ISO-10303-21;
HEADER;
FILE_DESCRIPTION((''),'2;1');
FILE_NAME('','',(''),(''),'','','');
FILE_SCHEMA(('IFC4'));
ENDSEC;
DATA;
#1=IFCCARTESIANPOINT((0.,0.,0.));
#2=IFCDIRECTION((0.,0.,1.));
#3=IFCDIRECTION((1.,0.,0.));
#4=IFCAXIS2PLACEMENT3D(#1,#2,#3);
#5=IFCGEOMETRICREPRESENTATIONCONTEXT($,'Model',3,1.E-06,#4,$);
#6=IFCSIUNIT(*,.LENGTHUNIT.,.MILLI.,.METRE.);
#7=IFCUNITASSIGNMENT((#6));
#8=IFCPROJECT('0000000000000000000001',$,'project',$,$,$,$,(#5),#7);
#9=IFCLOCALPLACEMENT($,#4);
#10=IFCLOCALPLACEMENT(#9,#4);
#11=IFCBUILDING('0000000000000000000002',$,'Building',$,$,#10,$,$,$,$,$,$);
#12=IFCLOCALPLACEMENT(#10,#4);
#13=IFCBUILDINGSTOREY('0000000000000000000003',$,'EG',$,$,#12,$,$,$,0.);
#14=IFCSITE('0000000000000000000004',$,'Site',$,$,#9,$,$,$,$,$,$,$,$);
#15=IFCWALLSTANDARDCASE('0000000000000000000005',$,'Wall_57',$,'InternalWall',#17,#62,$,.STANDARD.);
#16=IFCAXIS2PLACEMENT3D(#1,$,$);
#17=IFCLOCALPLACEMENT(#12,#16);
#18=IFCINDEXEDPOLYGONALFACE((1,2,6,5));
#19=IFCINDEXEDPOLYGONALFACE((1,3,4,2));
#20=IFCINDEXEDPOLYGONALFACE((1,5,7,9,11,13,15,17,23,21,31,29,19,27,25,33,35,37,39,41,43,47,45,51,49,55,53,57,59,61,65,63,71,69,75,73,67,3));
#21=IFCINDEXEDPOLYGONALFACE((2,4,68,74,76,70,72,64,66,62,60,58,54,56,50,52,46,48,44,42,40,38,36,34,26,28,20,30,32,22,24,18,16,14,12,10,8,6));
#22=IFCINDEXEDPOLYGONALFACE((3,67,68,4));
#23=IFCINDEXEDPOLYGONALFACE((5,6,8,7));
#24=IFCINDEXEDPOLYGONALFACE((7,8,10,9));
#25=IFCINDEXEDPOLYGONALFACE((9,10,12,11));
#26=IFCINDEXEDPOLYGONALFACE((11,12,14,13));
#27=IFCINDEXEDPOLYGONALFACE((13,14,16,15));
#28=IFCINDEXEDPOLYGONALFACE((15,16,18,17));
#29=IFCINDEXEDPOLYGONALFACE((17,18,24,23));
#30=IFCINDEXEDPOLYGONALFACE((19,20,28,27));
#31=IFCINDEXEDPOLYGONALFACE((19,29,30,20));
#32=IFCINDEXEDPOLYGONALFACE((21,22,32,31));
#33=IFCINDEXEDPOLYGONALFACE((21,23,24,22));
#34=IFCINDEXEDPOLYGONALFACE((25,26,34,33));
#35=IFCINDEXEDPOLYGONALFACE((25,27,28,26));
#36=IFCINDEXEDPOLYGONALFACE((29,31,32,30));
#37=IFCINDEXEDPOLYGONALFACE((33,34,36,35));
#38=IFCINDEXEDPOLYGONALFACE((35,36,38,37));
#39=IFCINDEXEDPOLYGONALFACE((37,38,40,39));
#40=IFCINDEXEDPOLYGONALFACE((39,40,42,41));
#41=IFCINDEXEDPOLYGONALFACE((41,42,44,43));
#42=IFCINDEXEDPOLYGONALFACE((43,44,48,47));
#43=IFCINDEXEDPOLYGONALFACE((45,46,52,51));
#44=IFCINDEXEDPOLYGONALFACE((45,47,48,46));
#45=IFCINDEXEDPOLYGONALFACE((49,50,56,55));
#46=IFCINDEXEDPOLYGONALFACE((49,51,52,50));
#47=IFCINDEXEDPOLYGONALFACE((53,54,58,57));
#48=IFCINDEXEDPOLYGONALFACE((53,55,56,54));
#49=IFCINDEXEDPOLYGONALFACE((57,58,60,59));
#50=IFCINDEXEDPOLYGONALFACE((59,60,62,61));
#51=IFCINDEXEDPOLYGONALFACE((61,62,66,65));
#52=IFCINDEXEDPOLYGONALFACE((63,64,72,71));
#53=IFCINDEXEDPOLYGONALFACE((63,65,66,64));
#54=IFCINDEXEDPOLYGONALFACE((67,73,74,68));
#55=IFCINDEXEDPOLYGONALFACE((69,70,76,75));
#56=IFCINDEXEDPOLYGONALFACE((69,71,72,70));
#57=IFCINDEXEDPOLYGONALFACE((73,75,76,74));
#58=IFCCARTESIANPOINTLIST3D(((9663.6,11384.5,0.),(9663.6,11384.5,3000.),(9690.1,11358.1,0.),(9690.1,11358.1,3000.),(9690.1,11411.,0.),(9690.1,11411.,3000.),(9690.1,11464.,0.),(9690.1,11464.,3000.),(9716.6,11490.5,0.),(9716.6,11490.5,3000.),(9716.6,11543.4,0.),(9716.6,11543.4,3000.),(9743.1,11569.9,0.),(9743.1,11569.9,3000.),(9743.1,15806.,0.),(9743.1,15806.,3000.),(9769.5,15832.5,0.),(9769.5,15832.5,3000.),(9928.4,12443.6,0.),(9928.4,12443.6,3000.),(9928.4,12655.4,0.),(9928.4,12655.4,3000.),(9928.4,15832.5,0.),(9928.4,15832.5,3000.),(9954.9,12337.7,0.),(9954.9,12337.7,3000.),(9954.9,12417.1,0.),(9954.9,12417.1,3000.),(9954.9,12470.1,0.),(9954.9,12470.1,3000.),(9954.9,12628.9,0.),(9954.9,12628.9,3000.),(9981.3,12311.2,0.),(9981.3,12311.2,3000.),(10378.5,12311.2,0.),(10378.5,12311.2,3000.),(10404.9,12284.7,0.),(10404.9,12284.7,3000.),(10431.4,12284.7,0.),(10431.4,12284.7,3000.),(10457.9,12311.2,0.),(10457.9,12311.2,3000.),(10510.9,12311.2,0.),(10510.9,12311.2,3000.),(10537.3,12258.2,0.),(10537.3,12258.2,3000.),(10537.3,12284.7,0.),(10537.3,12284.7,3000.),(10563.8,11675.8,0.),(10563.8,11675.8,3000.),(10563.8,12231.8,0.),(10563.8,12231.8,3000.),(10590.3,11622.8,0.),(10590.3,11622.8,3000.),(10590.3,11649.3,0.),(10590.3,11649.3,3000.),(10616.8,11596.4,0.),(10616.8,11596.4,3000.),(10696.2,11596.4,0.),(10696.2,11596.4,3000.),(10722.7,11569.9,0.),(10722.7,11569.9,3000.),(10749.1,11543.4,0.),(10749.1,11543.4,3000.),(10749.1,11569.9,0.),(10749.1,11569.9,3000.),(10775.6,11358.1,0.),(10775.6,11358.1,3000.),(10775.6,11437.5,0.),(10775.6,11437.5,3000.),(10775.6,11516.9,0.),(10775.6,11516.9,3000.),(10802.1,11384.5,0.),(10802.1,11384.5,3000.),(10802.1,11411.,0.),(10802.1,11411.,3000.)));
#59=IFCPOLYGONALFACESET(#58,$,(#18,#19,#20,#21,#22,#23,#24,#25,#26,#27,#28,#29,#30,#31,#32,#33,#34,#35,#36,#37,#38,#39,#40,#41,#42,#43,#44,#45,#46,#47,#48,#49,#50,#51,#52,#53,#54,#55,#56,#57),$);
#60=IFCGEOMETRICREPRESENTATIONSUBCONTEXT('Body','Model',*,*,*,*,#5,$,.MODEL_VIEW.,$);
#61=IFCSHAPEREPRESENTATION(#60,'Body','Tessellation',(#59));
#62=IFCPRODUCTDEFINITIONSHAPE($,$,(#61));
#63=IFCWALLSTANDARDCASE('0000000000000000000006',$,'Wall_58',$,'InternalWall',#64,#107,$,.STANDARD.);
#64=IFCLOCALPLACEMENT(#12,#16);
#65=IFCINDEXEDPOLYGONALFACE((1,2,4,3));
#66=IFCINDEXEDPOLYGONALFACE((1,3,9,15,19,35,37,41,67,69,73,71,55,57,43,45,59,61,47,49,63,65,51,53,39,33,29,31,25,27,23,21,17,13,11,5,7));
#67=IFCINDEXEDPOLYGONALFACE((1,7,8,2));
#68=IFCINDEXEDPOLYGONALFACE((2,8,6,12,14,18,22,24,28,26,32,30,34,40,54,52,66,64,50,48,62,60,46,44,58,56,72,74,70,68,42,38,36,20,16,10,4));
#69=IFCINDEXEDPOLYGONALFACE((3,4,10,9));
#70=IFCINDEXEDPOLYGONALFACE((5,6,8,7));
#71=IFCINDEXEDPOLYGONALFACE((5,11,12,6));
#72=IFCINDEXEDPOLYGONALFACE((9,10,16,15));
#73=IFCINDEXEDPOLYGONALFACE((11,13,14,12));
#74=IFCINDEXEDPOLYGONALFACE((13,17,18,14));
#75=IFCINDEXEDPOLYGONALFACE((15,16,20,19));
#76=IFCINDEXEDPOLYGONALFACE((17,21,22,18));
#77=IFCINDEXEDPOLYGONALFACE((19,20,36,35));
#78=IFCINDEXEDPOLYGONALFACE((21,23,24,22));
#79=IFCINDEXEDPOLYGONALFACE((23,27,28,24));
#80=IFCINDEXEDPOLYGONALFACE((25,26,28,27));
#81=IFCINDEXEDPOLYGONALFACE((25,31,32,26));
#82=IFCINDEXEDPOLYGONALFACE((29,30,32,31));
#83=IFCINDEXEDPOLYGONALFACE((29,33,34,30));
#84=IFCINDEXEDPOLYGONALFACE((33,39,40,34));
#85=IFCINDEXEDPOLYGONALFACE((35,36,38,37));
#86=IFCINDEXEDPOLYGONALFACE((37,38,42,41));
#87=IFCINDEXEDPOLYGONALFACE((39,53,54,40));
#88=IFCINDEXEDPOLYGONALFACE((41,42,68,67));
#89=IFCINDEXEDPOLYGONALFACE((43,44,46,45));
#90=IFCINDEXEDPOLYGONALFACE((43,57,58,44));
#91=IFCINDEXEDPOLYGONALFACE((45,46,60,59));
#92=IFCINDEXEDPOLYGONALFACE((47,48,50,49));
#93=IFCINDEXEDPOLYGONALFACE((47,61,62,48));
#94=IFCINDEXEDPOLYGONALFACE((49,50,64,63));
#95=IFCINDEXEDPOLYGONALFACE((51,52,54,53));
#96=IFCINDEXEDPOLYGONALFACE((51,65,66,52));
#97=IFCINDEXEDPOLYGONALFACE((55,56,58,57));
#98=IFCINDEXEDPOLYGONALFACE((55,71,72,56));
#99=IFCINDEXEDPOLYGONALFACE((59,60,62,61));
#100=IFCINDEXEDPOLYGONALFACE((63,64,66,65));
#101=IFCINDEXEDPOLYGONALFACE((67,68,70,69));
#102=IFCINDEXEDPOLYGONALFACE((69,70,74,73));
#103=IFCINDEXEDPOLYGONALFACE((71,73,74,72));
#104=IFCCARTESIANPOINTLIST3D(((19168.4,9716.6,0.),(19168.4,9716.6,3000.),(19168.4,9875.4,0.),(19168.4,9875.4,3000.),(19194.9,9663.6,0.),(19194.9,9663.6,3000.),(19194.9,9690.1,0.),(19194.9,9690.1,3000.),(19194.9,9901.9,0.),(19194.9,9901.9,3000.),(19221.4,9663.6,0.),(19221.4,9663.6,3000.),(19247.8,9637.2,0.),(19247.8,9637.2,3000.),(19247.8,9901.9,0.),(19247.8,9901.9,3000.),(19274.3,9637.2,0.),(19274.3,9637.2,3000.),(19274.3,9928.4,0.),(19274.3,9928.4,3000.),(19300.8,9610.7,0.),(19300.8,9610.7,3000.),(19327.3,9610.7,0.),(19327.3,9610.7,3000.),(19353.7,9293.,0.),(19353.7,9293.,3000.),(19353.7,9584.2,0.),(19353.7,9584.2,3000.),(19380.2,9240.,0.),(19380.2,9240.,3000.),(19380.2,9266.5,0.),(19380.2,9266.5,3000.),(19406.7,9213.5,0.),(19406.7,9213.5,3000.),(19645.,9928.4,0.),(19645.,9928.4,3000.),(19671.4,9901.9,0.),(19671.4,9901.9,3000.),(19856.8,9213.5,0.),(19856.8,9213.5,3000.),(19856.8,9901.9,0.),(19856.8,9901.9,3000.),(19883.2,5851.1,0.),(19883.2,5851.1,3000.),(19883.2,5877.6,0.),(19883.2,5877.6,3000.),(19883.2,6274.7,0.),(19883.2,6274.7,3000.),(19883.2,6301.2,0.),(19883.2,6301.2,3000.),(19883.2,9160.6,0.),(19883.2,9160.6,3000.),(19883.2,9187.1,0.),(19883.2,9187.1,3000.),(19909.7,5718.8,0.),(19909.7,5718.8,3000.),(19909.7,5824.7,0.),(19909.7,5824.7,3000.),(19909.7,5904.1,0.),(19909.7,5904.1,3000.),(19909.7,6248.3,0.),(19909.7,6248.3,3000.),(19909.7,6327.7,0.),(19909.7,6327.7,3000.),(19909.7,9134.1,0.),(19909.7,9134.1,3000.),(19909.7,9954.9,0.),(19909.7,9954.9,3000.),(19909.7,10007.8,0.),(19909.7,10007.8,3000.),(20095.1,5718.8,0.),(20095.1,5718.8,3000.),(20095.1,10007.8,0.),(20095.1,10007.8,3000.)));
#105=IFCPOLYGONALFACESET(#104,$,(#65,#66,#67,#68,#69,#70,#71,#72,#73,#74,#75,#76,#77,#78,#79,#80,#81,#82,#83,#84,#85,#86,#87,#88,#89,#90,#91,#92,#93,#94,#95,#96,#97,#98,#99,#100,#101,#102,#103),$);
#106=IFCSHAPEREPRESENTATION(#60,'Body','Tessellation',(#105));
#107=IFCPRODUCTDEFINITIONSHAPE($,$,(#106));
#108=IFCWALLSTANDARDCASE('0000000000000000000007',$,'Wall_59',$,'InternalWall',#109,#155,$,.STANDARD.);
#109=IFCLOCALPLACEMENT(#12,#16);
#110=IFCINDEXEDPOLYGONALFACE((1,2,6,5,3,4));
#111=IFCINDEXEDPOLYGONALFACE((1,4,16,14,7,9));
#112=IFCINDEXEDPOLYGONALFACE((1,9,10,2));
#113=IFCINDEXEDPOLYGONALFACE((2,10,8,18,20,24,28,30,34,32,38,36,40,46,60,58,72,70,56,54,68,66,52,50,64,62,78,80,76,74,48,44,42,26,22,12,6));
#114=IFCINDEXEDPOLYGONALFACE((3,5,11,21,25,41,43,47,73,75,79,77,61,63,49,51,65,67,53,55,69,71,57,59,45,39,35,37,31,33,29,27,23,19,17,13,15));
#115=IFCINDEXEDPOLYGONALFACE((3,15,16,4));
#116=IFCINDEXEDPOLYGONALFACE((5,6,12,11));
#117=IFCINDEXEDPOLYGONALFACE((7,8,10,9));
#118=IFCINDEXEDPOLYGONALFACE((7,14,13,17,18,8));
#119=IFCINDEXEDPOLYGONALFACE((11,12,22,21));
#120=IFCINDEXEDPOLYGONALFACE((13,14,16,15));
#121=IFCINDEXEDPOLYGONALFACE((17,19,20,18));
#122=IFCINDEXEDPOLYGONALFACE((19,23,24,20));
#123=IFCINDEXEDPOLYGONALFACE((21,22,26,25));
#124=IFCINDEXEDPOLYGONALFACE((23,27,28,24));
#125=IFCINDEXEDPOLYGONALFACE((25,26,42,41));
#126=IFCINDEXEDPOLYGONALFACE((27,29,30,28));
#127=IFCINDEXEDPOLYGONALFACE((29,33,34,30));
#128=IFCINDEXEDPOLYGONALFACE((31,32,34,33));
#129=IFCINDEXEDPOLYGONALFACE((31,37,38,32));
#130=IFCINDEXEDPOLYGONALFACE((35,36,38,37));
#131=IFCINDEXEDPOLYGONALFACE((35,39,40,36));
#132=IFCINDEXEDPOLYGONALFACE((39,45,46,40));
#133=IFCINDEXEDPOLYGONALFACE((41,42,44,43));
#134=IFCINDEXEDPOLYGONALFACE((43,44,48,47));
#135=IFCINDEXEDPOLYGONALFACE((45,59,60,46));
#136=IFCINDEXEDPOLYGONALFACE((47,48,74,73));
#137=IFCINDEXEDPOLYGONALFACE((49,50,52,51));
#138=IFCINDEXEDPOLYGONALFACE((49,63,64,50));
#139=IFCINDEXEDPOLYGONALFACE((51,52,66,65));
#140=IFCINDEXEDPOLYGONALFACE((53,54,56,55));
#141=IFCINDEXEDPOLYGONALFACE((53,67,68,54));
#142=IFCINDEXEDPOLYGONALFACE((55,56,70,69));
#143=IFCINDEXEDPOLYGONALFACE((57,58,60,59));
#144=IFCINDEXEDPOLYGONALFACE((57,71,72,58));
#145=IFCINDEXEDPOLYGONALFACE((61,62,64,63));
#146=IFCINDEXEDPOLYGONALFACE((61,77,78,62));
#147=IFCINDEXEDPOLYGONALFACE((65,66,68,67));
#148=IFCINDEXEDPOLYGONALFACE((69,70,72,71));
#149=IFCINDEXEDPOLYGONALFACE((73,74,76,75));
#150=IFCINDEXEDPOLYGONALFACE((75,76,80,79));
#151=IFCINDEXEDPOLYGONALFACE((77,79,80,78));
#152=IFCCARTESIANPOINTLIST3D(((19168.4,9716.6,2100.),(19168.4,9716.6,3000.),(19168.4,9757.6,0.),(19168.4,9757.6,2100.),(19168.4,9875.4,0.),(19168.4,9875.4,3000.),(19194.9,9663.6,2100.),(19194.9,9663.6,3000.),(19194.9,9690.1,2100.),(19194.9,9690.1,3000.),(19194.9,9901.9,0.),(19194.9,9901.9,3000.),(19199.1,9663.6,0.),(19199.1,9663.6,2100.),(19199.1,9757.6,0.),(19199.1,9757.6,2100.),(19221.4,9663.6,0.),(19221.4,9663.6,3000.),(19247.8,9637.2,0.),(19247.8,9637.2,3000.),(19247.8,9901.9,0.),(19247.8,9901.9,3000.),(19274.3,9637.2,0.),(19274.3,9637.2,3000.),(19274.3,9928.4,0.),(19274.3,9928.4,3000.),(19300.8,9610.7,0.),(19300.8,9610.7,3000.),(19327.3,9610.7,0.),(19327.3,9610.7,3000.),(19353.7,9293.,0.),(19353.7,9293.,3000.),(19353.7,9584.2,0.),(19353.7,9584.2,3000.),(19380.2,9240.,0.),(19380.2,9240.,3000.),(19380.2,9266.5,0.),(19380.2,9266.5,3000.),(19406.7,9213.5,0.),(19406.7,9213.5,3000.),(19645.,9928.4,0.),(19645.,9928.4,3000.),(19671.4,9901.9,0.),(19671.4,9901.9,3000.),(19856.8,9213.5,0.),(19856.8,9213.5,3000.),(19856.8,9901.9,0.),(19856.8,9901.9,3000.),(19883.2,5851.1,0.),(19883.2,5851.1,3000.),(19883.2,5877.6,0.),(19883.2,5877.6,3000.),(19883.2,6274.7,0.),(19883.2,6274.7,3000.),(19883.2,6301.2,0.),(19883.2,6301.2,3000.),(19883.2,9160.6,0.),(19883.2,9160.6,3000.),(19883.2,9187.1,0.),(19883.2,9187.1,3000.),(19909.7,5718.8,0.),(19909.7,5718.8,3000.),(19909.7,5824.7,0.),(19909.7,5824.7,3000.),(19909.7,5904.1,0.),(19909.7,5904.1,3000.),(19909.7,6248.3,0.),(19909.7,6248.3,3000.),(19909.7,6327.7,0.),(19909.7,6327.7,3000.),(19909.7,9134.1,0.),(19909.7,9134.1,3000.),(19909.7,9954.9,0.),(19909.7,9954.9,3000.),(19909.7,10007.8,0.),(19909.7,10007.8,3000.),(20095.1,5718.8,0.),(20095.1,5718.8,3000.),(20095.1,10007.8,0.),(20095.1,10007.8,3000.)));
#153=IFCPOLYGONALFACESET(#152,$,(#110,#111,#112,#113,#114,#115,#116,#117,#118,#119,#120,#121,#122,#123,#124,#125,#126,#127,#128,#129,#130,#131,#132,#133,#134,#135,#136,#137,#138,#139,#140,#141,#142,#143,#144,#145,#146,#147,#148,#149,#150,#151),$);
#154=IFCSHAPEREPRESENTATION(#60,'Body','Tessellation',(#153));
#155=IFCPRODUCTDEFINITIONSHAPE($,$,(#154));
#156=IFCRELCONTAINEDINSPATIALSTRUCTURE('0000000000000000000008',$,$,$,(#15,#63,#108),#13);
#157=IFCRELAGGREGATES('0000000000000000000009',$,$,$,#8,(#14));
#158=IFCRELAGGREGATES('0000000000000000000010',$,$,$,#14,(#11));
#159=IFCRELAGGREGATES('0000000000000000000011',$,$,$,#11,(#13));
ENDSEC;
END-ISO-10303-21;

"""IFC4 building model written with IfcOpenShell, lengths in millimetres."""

from ifc_helpers import new_model, si_unit, frame, origin_with_axes, place, context, subcontext, project, spatial, polyline, rectangle, outline, extrude, element, save


model = new_model("IFC4")

# Units and contexts
model_context = context("Model", 3, precision=1e-06, world=origin_with_axes())
body_context = subcontext(model_context, "Body", "Model", "MODEL_VIEW")
ifc_project = project(units=[si_unit("LENGTHUNIT", "METRE", prefix="MILLI")], contexts=[model_context])

# Site, building, storey
site_placement = place(None, origin_with_axes())
site = spatial("IfcSite", under=ifc_project, at=site_placement, Name="Site")
building_placement = place(site_placement, origin_with_axes())
building = spatial("IfcBuilding", under=site, at=building_placement, Name="Building")
storey_placement = place(building_placement, origin_with_axes())
storey = spatial("IfcBuildingStorey", under=building, at=storey_placement, Name="EG", Elevation=0.0)

# Walls
wall_1_placement = place(storey_placement, origin_with_axes())
element("IfcWallStandardCase", 1, at=wall_1_placement, inside=storey, Name="Wall_57", ObjectType="InternalWall", PredefinedType="STANDARD", context=body_context, shape_type="SweptSolid", body=[
    extrude(outline(polyline([(9690.1, 11358.1, 0.0), (9663.6, 11384.5, 0.0), (9690.1, 11411.0, 0.0), (9690.1, 11464.0, 0.0), (9716.6, 11490.5, 0.0), (9716.6, 11543.4, 0.0), (9743.1, 11569.9, 0.0), (9743.1, 15806.0, 0.0), (9769.5, 15832.5, 0.0), (9928.4, 15832.5, 0.0), (9928.4, 12655.4, 0.0), (9954.9, 12628.9, 0.0), (9954.9, 12470.1, 0.0), (9928.4, 12443.6, 0.0), (9954.9, 12417.1, 0.0), (9954.9, 12337.7, 0.0), (9981.3, 12311.2, 0.0), (10378.5, 12311.2, 0.0), (10404.9, 12284.7, 0.0), (10431.4, 12284.7, 0.0), (10457.9, 12311.2, 0.0), (10510.9, 12311.2, 0.0), (10537.3, 12284.7, 0.0), (10537.3, 12258.2, 0.0), (10563.8, 12231.8, 0.0), (10563.8, 11675.8, 0.0), (10590.3, 11649.3, 0.0), (10590.3, 11622.8, 0.0), (10616.8, 11596.4, 0.0), (10696.2, 11596.4, 0.0), (10722.7, 11569.9, 0.0), (10749.1, 11569.9, 0.0), (10749.1, 11543.4, 0.0), (10775.6, 11516.9, 0.0), (10775.6, 11437.5, 0.0), (10802.1, 11411.0, 0.0), (10802.1, 11384.5, 0.0), (10775.6, 11358.1, 0.0), (9690.1, 11358.1, 0.0)])), origin_with_axes(), (0.0, 0.0, 1.0), 3000.0),
])
wall_2_placement = place(storey_placement, origin_with_axes())
element("IfcWallStandardCase", 2, at=wall_2_placement, inside=storey, Name="Wall_58", ObjectType="InternalWall", PredefinedType="STANDARD", context=body_context, shape_type="SweptSolid", body=[
    extrude(outline(polyline([(19909.7, 5718.8, 0.0), (19909.7, 5824.7, 0.0), (19883.2, 5851.1, 0.0), (19883.2, 5877.6, 0.0), (19909.7, 5904.1, 0.0), (19909.7, 6248.3, 0.0), (19883.2, 6274.7, 0.0), (19883.2, 6301.2, 0.0), (19909.7, 6327.7, 0.0), (19909.7, 9134.1, 0.0), (19883.2, 9160.6, 0.0), (19883.2, 9187.1, 0.0), (19856.8, 9213.5, 0.0), (19406.7, 9213.5, 0.0), (19380.2, 9240.0, 0.0), (19380.2, 9266.5, 0.0), (19353.7, 9293.0, 0.0), (19353.7, 9584.2, 0.0), (19327.3, 9610.7, 0.0), (19300.8, 9610.7, 0.0), (19274.3, 9637.2, 0.0), (19247.8, 9637.2, 0.0), (19221.4, 9663.6, 0.0), (19194.9, 9663.6, 0.0), (19194.9, 9690.1, 0.0), (19168.4, 9716.6, 0.0), (19168.4, 9875.4, 0.0), (19194.9, 9901.9, 0.0), (19247.8, 9901.9, 0.0), (19274.3, 9928.4, 0.0), (19645.0, 9928.4, 0.0), (19671.4, 9901.9, 0.0), (19856.8, 9901.9, 0.0), (19909.7, 9954.9, 0.0), (19909.7, 10007.8, 0.0), (20095.1, 10007.8, 0.0), (20095.1, 5718.8, 0.0), (19909.7, 5718.8, 0.0)])), origin_with_axes(), (0.0, 0.0, 1.0), 3000.0),
])

# Wall, opening
wall_3_placement = place(storey_placement, origin_with_axes())
wall_3 = element("IfcWallStandardCase", 3, at=wall_3_placement, inside=storey, Name="Wall_59", ObjectType="InternalWall", PredefinedType="STANDARD", context=body_context, shape_type="SweptSolid", body=[
    extrude(outline(polyline([(19909.7, 5718.8, 0.0), (19909.7, 5824.7, 0.0), (19883.2, 5851.1, 0.0), (19883.2, 5877.6, 0.0), (19909.7, 5904.1, 0.0), (19909.7, 6248.3, 0.0), (19883.2, 6274.7, 0.0), (19883.2, 6301.2, 0.0), (19909.7, 6327.7, 0.0), (19909.7, 9134.1, 0.0), (19883.2, 9160.6, 0.0), (19883.2, 9187.1, 0.0), (19856.8, 9213.5, 0.0), (19406.7, 9213.5, 0.0), (19380.2, 9240.0, 0.0), (19380.2, 9266.5, 0.0), (19353.7, 9293.0, 0.0), (19353.7, 9584.2, 0.0), (19327.3, 9610.7, 0.0), (19300.8, 9610.7, 0.0), (19274.3, 9637.2, 0.0), (19247.8, 9637.2, 0.0), (19221.4, 9663.6, 0.0), (19194.9, 9663.6, 0.0), (19194.9, 9690.1, 0.0), (19168.4, 9716.6, 0.0), (19168.4, 9875.4, 0.0), (19194.9, 9901.9, 0.0), (19247.8, 9901.9, 0.0), (19274.3, 9928.4, 0.0), (19645.0, 9928.4, 0.0), (19671.4, 9901.9, 0.0), (19856.8, 9901.9, 0.0), (19909.7, 9954.9, 0.0), (19909.7, 10007.8, 0.0), (20095.1, 10007.8, 0.0), (20095.1, 5718.8, 0.0), (19909.7, 5718.8, 0.0)])), origin_with_axes(), (0.0, 0.0, 1.0), 3000.0),
])
opening_1_placement = place(wall_3_placement, origin_with_axes())
element("IfcOpeningElement", 4, at=opening_1_placement, inside=storey, cuts=wall_3, context=body_context, shape_type="SweptSolid", body=[
    extrude(rectangle(XDim=926.6, YDim=400.0), frame((18735.7, 9557.6, 0.0), z_axis=(0.0, 0.0, 1.0), x_axis=(1.0, 0.0, 0.0)), (0.0, 0.0, 1.0), 2100.0),
])

save(model, "model.ifc")
